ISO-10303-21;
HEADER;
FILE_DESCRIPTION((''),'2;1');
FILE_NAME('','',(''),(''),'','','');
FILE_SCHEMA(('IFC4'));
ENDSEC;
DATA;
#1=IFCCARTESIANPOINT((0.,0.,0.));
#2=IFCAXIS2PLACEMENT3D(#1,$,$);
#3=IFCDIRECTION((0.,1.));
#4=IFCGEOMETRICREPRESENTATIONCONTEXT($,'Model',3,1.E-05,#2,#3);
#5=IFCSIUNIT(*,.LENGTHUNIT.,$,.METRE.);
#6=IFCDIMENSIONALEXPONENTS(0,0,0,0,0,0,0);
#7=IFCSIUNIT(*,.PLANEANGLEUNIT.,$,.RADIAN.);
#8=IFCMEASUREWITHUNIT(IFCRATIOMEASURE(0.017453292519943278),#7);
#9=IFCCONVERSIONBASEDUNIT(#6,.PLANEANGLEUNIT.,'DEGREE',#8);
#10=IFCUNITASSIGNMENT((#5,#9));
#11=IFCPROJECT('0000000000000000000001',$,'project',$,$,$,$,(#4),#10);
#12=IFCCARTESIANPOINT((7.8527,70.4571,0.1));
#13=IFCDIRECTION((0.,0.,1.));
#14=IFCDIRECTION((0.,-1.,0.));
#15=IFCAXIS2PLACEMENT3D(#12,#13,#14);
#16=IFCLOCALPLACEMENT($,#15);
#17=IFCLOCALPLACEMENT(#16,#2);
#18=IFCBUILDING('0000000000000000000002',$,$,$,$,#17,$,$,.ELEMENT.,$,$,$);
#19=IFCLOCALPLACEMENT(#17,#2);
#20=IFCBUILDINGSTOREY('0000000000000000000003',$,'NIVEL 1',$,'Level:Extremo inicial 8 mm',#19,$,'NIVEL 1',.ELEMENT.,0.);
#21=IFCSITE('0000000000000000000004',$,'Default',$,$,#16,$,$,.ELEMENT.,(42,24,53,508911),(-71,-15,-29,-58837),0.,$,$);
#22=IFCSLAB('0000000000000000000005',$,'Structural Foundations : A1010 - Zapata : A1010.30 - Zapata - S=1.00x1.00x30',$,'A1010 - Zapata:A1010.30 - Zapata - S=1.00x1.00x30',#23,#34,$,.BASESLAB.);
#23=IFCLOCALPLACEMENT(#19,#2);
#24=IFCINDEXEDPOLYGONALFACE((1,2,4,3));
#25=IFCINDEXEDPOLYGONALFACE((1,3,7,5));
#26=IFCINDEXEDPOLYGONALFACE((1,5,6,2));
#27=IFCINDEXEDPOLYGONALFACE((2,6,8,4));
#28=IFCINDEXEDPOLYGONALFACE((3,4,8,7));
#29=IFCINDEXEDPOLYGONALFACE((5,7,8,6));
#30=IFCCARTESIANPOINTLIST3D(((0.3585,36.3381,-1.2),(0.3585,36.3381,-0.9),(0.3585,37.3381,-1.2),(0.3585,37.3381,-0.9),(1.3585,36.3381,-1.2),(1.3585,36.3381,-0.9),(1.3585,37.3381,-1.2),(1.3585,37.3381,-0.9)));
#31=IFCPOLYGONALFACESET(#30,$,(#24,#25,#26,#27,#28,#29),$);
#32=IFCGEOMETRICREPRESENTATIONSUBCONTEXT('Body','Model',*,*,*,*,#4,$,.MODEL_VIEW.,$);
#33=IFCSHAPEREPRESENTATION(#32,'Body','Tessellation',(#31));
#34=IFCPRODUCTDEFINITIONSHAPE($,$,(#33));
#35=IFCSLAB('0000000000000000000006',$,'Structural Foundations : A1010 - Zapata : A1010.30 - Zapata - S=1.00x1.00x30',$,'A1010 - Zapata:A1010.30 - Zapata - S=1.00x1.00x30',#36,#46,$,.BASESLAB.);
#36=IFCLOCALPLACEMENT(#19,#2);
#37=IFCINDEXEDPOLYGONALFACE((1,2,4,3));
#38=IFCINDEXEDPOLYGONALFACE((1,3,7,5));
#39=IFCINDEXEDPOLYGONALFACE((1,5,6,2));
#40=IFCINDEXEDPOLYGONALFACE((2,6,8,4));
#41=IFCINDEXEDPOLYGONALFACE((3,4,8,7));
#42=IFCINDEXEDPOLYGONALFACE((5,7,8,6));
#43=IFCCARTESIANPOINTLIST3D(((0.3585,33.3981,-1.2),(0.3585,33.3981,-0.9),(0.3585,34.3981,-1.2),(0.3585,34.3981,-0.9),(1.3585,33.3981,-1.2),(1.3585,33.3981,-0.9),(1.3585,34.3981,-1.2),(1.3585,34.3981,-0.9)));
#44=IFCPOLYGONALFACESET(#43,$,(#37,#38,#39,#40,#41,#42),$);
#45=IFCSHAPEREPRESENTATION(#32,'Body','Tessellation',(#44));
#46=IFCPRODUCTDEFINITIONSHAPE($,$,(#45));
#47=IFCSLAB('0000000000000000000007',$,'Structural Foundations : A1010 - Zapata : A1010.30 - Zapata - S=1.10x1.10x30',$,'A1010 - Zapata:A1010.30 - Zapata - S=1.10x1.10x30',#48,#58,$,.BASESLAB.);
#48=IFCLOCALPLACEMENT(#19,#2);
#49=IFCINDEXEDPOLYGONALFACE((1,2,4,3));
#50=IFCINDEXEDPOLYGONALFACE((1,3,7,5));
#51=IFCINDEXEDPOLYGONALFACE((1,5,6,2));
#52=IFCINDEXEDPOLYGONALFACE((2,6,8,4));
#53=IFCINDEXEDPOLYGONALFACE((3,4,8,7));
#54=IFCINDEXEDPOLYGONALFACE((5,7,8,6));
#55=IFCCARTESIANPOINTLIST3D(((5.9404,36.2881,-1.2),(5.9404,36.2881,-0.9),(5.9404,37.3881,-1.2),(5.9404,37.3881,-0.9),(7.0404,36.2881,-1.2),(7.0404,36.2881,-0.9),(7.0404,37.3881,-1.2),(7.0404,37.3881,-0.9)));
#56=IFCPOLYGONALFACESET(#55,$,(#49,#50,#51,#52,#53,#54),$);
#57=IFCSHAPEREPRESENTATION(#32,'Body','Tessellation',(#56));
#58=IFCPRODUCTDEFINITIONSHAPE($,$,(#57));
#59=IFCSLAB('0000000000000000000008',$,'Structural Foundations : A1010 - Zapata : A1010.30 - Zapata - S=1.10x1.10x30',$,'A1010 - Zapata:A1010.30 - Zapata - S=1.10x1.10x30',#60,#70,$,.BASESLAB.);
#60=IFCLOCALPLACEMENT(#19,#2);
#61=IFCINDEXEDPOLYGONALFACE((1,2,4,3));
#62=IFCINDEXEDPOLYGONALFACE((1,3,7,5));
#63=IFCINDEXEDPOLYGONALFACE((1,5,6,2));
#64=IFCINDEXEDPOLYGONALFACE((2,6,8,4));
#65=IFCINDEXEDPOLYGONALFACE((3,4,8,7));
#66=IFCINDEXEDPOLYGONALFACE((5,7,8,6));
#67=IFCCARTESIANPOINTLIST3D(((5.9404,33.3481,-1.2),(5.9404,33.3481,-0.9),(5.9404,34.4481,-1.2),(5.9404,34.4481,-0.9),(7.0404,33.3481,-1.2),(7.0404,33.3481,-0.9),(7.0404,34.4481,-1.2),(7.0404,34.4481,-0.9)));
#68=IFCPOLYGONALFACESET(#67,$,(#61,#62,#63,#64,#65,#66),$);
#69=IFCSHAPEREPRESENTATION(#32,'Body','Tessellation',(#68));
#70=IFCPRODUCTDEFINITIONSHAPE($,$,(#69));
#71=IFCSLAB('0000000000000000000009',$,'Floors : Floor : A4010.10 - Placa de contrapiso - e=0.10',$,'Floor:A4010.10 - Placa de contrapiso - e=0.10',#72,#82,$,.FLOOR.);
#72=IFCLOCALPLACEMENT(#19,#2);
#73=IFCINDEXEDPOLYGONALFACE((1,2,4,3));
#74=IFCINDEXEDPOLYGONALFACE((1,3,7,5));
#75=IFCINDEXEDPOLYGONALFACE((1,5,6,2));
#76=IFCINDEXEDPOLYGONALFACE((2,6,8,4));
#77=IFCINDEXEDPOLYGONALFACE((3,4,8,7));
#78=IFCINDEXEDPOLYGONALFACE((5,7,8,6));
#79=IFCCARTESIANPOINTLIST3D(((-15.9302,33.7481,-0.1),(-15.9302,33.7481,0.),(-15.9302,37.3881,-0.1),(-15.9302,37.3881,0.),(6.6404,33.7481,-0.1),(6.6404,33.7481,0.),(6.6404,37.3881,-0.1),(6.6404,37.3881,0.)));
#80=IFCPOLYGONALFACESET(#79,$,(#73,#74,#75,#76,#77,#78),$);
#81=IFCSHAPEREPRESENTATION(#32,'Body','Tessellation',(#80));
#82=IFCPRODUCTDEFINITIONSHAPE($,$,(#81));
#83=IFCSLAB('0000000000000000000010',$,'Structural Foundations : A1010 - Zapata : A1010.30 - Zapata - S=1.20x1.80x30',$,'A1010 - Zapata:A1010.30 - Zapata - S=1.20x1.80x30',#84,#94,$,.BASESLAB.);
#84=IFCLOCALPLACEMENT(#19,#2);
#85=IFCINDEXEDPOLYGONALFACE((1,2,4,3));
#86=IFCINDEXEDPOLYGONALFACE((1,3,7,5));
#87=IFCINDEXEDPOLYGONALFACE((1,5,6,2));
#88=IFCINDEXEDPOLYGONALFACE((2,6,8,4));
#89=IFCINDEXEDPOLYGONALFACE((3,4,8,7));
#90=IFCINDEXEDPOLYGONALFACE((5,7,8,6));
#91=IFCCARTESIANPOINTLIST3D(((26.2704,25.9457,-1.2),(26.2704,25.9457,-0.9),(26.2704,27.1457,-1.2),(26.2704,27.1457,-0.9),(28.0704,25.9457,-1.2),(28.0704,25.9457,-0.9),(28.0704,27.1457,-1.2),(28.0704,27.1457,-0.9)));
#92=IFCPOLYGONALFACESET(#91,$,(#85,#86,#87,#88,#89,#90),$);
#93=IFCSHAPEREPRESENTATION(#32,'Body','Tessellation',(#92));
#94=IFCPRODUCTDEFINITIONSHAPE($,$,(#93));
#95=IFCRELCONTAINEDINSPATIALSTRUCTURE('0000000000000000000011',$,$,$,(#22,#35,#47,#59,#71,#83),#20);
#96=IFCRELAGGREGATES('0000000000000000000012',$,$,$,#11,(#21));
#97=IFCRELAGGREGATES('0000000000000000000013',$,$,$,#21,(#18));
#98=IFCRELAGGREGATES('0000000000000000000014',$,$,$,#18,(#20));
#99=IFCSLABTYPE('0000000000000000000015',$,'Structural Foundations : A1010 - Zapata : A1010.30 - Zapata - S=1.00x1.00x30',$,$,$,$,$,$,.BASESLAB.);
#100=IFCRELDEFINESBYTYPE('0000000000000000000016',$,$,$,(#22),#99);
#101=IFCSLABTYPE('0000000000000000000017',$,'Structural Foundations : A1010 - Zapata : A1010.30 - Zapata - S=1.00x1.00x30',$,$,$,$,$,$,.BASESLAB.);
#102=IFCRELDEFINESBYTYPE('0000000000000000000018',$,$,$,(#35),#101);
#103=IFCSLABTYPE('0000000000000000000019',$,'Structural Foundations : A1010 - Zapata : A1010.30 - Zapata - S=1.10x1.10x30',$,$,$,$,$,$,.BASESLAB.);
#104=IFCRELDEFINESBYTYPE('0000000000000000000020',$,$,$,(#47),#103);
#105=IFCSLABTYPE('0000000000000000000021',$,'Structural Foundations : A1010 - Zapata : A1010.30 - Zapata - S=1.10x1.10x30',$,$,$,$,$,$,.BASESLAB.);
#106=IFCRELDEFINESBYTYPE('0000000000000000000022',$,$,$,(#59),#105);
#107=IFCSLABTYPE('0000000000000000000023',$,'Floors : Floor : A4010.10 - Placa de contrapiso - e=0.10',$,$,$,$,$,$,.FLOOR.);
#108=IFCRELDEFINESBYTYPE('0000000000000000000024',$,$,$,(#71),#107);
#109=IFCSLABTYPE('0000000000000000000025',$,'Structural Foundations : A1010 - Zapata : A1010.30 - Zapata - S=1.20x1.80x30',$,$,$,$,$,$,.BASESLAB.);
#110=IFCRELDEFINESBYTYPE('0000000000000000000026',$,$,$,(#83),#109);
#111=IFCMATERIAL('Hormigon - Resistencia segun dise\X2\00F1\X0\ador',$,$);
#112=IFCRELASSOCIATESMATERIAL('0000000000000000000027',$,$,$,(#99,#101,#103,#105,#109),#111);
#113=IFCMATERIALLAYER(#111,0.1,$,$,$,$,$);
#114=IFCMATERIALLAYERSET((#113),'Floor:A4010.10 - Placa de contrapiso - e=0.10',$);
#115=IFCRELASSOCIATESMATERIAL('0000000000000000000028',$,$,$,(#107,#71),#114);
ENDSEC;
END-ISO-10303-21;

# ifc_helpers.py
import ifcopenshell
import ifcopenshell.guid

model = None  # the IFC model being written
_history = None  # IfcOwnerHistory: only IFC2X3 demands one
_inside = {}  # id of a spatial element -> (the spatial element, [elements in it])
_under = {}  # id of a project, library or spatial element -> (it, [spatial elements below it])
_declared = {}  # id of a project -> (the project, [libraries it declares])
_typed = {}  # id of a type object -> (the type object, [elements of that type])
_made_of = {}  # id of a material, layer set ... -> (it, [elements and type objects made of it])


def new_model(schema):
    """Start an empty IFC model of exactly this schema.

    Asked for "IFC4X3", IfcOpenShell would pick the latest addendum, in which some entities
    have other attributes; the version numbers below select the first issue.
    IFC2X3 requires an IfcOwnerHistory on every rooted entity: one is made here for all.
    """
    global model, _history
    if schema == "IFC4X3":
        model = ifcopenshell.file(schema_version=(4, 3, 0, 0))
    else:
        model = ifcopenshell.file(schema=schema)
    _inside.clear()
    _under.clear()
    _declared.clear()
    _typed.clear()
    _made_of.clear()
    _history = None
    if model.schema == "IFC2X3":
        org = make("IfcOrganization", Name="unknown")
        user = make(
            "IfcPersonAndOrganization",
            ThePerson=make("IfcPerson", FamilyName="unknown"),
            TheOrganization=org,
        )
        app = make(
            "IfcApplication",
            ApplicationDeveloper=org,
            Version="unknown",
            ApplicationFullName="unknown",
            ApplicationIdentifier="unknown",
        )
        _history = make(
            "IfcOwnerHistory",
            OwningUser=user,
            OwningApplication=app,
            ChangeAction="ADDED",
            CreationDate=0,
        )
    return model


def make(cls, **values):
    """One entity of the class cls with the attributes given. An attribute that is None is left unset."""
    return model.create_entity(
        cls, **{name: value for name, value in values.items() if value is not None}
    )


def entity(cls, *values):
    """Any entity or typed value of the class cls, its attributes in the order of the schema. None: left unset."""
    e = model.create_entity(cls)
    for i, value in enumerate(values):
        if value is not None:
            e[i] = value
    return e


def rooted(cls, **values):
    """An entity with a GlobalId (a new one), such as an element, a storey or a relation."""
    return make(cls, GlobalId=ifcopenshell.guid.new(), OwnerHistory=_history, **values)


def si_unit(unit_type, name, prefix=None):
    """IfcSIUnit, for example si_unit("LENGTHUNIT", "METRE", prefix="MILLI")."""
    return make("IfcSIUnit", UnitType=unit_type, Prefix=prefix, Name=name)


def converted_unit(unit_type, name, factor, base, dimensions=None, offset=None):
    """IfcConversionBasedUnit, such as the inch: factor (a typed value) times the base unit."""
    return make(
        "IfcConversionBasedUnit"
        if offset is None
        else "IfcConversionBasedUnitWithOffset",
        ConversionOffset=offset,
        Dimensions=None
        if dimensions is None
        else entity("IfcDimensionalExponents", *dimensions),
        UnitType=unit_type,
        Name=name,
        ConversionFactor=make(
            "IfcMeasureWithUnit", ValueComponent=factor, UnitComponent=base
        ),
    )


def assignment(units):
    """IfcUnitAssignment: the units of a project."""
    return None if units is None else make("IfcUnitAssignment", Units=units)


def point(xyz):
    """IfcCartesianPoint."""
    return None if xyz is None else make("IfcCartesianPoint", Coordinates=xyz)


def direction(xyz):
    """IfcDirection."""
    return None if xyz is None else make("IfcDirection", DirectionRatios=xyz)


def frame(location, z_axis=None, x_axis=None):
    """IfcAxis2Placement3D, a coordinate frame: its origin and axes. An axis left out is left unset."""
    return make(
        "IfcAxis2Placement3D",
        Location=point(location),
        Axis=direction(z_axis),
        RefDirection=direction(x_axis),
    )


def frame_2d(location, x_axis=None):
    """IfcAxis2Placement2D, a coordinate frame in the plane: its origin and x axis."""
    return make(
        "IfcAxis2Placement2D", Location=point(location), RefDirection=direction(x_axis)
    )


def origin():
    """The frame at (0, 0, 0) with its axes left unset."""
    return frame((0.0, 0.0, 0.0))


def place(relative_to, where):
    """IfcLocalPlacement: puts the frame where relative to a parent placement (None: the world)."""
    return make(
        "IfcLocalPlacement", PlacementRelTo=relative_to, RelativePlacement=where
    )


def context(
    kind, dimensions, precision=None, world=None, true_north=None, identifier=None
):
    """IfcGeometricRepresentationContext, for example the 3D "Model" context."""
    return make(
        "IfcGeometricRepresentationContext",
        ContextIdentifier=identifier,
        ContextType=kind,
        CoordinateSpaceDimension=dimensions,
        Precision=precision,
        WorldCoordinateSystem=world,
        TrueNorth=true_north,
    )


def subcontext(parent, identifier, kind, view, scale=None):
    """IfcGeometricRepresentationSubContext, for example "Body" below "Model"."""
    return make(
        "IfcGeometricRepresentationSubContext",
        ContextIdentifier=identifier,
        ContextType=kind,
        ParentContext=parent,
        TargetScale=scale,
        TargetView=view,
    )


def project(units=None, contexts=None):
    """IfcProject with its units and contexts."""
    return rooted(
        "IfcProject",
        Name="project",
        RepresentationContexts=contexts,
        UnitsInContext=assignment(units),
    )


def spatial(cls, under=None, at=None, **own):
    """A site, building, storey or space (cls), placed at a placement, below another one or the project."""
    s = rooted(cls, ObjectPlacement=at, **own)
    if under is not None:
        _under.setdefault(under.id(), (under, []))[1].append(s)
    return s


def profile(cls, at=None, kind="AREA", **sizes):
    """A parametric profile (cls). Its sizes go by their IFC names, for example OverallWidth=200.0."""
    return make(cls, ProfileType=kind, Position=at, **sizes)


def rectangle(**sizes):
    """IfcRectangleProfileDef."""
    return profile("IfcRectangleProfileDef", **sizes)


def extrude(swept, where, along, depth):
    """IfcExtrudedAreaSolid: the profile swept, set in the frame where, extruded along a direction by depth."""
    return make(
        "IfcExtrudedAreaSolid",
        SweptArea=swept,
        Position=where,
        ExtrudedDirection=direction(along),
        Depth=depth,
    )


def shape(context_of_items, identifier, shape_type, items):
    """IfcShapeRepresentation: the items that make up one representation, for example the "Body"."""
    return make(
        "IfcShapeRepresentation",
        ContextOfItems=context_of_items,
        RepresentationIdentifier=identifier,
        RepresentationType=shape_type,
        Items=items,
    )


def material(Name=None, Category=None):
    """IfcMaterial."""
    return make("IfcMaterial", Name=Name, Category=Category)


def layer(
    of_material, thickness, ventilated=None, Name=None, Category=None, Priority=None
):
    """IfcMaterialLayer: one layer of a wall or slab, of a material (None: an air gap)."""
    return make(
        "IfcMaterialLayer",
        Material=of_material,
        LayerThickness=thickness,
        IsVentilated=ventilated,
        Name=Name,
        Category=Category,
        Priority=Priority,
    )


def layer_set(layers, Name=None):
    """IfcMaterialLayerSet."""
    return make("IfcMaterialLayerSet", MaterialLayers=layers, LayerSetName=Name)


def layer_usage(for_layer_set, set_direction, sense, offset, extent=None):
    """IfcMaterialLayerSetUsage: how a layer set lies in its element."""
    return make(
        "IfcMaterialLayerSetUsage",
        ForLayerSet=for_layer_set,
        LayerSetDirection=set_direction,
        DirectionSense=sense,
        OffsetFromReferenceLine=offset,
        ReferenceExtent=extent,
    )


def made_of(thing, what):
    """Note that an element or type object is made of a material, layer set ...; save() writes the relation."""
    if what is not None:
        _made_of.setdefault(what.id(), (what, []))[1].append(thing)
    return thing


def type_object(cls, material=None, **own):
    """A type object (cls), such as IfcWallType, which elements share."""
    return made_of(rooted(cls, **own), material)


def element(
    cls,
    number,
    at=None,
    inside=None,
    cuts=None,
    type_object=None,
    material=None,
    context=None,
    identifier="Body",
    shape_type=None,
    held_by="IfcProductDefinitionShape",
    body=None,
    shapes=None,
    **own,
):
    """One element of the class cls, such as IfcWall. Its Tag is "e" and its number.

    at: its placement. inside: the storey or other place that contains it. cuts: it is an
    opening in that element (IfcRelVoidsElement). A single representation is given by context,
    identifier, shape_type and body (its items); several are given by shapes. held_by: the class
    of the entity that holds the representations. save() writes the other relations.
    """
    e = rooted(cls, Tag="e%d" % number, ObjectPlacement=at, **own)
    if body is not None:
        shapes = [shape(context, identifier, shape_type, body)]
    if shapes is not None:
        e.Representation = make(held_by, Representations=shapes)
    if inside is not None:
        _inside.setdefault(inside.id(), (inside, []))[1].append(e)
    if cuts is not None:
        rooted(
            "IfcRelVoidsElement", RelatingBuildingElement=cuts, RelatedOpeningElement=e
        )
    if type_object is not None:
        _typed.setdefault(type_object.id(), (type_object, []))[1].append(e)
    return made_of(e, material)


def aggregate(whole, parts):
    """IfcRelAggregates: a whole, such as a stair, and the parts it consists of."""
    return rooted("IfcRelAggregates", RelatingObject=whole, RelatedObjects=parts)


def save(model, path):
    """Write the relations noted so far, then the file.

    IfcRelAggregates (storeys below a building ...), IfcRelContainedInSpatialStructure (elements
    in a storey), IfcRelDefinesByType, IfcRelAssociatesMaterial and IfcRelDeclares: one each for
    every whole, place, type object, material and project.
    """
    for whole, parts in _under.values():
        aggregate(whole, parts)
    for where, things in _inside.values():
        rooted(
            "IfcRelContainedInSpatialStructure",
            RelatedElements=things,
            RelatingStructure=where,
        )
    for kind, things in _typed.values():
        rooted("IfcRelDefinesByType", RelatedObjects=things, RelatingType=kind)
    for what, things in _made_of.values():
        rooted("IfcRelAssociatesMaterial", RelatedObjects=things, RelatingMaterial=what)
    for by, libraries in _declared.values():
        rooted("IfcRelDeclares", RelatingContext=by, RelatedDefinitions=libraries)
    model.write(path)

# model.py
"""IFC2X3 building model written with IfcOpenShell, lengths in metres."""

from ifc_helpers import new_model, entity, si_unit, converted_unit, direction, frame, frame_2d, origin, place, context, subcontext, project, spatial, rectangle, extrude, material, layer, layer_set, layer_usage, type_object, element, save


model = new_model("IFC2X3")

# Units and contexts
model_context = context("Model", 3, precision=1e-05, world=origin(), true_north=direction((0.0, 1.0)))
body_context = subcontext(model_context, "Body", "Model", "MODEL_VIEW")
ifc_project = project(units=[si_unit("LENGTHUNIT", "METRE"), converted_unit("PLANEANGLEUNIT", "DEGREE", entity("IfcRatioMeasure", 0.017453292519943278), si_unit("PLANEANGLEUNIT", "RADIAN"), dimensions=[0, 0, 0, 0, 0, 0, 0])], contexts=[model_context])

# Site, building, storey
site_placement = place(None, frame((7.8527, 70.4571, 0.1), z_axis=(0.0, 0.0, 1.0), x_axis=(0.0, -1.0, 0.0)))
site = spatial("IfcSite", under=ifc_project, at=site_placement, Name="Default", CompositionType="ELEMENT", RefLatitude=(42, 24, 53, 508911), RefLongitude=(-71, -15, -29, -58837), RefElevation=0.0)
building_placement = place(site_placement, origin())
building = spatial("IfcBuilding", under=site, at=building_placement, CompositionType="ELEMENT")
storey_placement = place(building_placement, origin())
storey = spatial("IfcBuildingStorey", under=building, at=storey_placement, Name="NIVEL 1", ObjectType="Level:Extremo inicial 8 mm", LongName="NIVEL 1", CompositionType="ELEMENT", Elevation=0.0)

# Slabs
ifc_material_1 = material(Name="Hormigon - Resistencia segun diseñador")
slab_type_1 = type_object("IfcSlabType", Name="Structural Foundations : A1010 - Zapata : A1010.30 - Zapata - S=1.00x1.00x30", PredefinedType="BASESLAB", material=ifc_material_1)
slab_1_placement = place(storey_placement, origin())
element("IfcSlab", 1, at=slab_1_placement, inside=storey, type_object=slab_type_1, Name="Structural Foundations : A1010 - Zapata : A1010.30 - Zapata - S=1.00x1.00x30", ObjectType="A1010 - Zapata:A1010.30 - Zapata - S=1.00x1.00x30", PredefinedType="BASESLAB", context=body_context, shape_type="SweptSolid", body=[
    extrude(rectangle(XDim=1.0, YDim=1.0, at=frame_2d((0.0, 0.0), x_axis=(1.0, 0.0))), frame((0.8585, 36.8381, -1.2), z_axis=(0.0, 0.0, 1.0), x_axis=(-1.0, 0.0, 0.0)), (0.0, 0.0, 1.0), 0.3),
])
slab_type_2 = type_object("IfcSlabType", Name="Structural Foundations : A1010 - Zapata : A1010.30 - Zapata - S=1.00x1.00x30", PredefinedType="BASESLAB", material=ifc_material_1)
slab_2_placement = place(storey_placement, origin())
element("IfcSlab", 2, at=slab_2_placement, inside=storey, type_object=slab_type_2, Name="Structural Foundations : A1010 - Zapata : A1010.30 - Zapata - S=1.00x1.00x30", ObjectType="A1010 - Zapata:A1010.30 - Zapata - S=1.00x1.00x30", PredefinedType="BASESLAB", context=body_context, shape_type="SweptSolid", body=[
    extrude(rectangle(XDim=1.0, YDim=1.0, at=frame_2d((0.0, 0.0), x_axis=(1.0, 0.0))), frame((0.8585, 33.8981, -1.2), z_axis=(0.0, 0.0, 1.0), x_axis=(-1.0, 0.0, 0.0)), (0.0, 0.0, 1.0), 0.3),
])
slab_type_3 = type_object("IfcSlabType", Name="Structural Foundations : A1010 - Zapata : A1010.30 - Zapata - S=1.10x1.10x30", PredefinedType="BASESLAB", material=ifc_material_1)
slab_3_placement = place(storey_placement, origin())
element("IfcSlab", 3, at=slab_3_placement, inside=storey, type_object=slab_type_3, Name="Structural Foundations : A1010 - Zapata : A1010.30 - Zapata - S=1.10x1.10x30", ObjectType="A1010 - Zapata:A1010.30 - Zapata - S=1.10x1.10x30", PredefinedType="BASESLAB", context=body_context, shape_type="SweptSolid", body=[
    extrude(rectangle(XDim=1.1, YDim=1.1, at=frame_2d((0.0, 0.0), x_axis=(1.0, 0.0))), frame((6.4904, 36.8381, -1.2), z_axis=(0.0, 0.0, 1.0), x_axis=(-1.0, 0.0, 0.0)), (0.0, 0.0, 1.0), 0.3),
])
slab_type_4 = type_object("IfcSlabType", Name="Structural Foundations : A1010 - Zapata : A1010.30 - Zapata - S=1.10x1.10x30", PredefinedType="BASESLAB", material=ifc_material_1)
slab_4_placement = place(storey_placement, origin())
element("IfcSlab", 4, at=slab_4_placement, inside=storey, type_object=slab_type_4, Name="Structural Foundations : A1010 - Zapata : A1010.30 - Zapata - S=1.10x1.10x30", ObjectType="A1010 - Zapata:A1010.30 - Zapata - S=1.10x1.10x30", PredefinedType="BASESLAB", context=body_context, shape_type="SweptSolid", body=[
    extrude(rectangle(XDim=1.1, YDim=1.1, at=frame_2d((0.0, 0.0), x_axis=(1.0, 0.0))), frame((6.4904, 33.8981, -1.2), z_axis=(0.0, 0.0, 1.0), x_axis=(-1.0, 0.0, 0.0)), (0.0, 0.0, 1.0), 0.3),
])
ifc_layer = layer(ifc_material_1, 0.1)
ifc_layer_set = layer_set([ifc_layer], Name="Floor:A4010.10 - Placa de contrapiso - e=0.10")
ifc_layer_usage_1 = layer_usage(ifc_layer_set, "AXIS3", "POSITIVE", 0.0)
slab_type_5 = type_object("IfcSlabType", Name="Floors : Floor : A4010.10 - Placa de contrapiso - e=0.10", PredefinedType="FLOOR", material=ifc_layer_set)
slab_5_placement = place(storey_placement, origin())
element("IfcSlab", 5, at=slab_5_placement, inside=storey, type_object=slab_type_5, material=ifc_layer_usage_1, Name="Floors : Floor : A4010.10 - Placa de contrapiso - e=0.10", ObjectType="Floor:A4010.10 - Placa de contrapiso - e=0.10", PredefinedType="FLOOR", context=body_context, shape_type="SweptSolid", body=[
    extrude(rectangle(XDim=3.6399, YDim=22.5706, at=frame_2d((0.0, 0.0), x_axis=(1.0, 0.0))), frame((-4.6449, 35.5681, 0.0), z_axis=(0.0, 0.0, -1.0), x_axis=(0.0, 1.0, 0.0)), (0.0, 0.0, 1.0), 0.1),
])
slab_type_6 = type_object("IfcSlabType", Name="Structural Foundations : A1010 - Zapata : A1010.30 - Zapata - S=1.20x1.80x30", PredefinedType="BASESLAB", material=ifc_material_1)
slab_6_placement = place(storey_placement, origin())
element("IfcSlab", 6, at=slab_6_placement, inside=storey, type_object=slab_type_6, Name="Structural Foundations : A1010 - Zapata : A1010.30 - Zapata - S=1.20x1.80x30", ObjectType="A1010 - Zapata:A1010.30 - Zapata - S=1.20x1.80x30", PredefinedType="BASESLAB", context=body_context, shape_type="SweptSolid", body=[
    extrude(rectangle(XDim=1.2, YDim=1.8, at=frame_2d((0.0, 0.0), x_axis=(1.0, 0.0))), frame((27.1704, 26.5457, -1.2), z_axis=(0.0, 0.0, 1.0), x_axis=(0.0, -1.0, 0.0)), (0.0, 0.0, 1.0), 0.3),
])

save(model, "model.ifc")
